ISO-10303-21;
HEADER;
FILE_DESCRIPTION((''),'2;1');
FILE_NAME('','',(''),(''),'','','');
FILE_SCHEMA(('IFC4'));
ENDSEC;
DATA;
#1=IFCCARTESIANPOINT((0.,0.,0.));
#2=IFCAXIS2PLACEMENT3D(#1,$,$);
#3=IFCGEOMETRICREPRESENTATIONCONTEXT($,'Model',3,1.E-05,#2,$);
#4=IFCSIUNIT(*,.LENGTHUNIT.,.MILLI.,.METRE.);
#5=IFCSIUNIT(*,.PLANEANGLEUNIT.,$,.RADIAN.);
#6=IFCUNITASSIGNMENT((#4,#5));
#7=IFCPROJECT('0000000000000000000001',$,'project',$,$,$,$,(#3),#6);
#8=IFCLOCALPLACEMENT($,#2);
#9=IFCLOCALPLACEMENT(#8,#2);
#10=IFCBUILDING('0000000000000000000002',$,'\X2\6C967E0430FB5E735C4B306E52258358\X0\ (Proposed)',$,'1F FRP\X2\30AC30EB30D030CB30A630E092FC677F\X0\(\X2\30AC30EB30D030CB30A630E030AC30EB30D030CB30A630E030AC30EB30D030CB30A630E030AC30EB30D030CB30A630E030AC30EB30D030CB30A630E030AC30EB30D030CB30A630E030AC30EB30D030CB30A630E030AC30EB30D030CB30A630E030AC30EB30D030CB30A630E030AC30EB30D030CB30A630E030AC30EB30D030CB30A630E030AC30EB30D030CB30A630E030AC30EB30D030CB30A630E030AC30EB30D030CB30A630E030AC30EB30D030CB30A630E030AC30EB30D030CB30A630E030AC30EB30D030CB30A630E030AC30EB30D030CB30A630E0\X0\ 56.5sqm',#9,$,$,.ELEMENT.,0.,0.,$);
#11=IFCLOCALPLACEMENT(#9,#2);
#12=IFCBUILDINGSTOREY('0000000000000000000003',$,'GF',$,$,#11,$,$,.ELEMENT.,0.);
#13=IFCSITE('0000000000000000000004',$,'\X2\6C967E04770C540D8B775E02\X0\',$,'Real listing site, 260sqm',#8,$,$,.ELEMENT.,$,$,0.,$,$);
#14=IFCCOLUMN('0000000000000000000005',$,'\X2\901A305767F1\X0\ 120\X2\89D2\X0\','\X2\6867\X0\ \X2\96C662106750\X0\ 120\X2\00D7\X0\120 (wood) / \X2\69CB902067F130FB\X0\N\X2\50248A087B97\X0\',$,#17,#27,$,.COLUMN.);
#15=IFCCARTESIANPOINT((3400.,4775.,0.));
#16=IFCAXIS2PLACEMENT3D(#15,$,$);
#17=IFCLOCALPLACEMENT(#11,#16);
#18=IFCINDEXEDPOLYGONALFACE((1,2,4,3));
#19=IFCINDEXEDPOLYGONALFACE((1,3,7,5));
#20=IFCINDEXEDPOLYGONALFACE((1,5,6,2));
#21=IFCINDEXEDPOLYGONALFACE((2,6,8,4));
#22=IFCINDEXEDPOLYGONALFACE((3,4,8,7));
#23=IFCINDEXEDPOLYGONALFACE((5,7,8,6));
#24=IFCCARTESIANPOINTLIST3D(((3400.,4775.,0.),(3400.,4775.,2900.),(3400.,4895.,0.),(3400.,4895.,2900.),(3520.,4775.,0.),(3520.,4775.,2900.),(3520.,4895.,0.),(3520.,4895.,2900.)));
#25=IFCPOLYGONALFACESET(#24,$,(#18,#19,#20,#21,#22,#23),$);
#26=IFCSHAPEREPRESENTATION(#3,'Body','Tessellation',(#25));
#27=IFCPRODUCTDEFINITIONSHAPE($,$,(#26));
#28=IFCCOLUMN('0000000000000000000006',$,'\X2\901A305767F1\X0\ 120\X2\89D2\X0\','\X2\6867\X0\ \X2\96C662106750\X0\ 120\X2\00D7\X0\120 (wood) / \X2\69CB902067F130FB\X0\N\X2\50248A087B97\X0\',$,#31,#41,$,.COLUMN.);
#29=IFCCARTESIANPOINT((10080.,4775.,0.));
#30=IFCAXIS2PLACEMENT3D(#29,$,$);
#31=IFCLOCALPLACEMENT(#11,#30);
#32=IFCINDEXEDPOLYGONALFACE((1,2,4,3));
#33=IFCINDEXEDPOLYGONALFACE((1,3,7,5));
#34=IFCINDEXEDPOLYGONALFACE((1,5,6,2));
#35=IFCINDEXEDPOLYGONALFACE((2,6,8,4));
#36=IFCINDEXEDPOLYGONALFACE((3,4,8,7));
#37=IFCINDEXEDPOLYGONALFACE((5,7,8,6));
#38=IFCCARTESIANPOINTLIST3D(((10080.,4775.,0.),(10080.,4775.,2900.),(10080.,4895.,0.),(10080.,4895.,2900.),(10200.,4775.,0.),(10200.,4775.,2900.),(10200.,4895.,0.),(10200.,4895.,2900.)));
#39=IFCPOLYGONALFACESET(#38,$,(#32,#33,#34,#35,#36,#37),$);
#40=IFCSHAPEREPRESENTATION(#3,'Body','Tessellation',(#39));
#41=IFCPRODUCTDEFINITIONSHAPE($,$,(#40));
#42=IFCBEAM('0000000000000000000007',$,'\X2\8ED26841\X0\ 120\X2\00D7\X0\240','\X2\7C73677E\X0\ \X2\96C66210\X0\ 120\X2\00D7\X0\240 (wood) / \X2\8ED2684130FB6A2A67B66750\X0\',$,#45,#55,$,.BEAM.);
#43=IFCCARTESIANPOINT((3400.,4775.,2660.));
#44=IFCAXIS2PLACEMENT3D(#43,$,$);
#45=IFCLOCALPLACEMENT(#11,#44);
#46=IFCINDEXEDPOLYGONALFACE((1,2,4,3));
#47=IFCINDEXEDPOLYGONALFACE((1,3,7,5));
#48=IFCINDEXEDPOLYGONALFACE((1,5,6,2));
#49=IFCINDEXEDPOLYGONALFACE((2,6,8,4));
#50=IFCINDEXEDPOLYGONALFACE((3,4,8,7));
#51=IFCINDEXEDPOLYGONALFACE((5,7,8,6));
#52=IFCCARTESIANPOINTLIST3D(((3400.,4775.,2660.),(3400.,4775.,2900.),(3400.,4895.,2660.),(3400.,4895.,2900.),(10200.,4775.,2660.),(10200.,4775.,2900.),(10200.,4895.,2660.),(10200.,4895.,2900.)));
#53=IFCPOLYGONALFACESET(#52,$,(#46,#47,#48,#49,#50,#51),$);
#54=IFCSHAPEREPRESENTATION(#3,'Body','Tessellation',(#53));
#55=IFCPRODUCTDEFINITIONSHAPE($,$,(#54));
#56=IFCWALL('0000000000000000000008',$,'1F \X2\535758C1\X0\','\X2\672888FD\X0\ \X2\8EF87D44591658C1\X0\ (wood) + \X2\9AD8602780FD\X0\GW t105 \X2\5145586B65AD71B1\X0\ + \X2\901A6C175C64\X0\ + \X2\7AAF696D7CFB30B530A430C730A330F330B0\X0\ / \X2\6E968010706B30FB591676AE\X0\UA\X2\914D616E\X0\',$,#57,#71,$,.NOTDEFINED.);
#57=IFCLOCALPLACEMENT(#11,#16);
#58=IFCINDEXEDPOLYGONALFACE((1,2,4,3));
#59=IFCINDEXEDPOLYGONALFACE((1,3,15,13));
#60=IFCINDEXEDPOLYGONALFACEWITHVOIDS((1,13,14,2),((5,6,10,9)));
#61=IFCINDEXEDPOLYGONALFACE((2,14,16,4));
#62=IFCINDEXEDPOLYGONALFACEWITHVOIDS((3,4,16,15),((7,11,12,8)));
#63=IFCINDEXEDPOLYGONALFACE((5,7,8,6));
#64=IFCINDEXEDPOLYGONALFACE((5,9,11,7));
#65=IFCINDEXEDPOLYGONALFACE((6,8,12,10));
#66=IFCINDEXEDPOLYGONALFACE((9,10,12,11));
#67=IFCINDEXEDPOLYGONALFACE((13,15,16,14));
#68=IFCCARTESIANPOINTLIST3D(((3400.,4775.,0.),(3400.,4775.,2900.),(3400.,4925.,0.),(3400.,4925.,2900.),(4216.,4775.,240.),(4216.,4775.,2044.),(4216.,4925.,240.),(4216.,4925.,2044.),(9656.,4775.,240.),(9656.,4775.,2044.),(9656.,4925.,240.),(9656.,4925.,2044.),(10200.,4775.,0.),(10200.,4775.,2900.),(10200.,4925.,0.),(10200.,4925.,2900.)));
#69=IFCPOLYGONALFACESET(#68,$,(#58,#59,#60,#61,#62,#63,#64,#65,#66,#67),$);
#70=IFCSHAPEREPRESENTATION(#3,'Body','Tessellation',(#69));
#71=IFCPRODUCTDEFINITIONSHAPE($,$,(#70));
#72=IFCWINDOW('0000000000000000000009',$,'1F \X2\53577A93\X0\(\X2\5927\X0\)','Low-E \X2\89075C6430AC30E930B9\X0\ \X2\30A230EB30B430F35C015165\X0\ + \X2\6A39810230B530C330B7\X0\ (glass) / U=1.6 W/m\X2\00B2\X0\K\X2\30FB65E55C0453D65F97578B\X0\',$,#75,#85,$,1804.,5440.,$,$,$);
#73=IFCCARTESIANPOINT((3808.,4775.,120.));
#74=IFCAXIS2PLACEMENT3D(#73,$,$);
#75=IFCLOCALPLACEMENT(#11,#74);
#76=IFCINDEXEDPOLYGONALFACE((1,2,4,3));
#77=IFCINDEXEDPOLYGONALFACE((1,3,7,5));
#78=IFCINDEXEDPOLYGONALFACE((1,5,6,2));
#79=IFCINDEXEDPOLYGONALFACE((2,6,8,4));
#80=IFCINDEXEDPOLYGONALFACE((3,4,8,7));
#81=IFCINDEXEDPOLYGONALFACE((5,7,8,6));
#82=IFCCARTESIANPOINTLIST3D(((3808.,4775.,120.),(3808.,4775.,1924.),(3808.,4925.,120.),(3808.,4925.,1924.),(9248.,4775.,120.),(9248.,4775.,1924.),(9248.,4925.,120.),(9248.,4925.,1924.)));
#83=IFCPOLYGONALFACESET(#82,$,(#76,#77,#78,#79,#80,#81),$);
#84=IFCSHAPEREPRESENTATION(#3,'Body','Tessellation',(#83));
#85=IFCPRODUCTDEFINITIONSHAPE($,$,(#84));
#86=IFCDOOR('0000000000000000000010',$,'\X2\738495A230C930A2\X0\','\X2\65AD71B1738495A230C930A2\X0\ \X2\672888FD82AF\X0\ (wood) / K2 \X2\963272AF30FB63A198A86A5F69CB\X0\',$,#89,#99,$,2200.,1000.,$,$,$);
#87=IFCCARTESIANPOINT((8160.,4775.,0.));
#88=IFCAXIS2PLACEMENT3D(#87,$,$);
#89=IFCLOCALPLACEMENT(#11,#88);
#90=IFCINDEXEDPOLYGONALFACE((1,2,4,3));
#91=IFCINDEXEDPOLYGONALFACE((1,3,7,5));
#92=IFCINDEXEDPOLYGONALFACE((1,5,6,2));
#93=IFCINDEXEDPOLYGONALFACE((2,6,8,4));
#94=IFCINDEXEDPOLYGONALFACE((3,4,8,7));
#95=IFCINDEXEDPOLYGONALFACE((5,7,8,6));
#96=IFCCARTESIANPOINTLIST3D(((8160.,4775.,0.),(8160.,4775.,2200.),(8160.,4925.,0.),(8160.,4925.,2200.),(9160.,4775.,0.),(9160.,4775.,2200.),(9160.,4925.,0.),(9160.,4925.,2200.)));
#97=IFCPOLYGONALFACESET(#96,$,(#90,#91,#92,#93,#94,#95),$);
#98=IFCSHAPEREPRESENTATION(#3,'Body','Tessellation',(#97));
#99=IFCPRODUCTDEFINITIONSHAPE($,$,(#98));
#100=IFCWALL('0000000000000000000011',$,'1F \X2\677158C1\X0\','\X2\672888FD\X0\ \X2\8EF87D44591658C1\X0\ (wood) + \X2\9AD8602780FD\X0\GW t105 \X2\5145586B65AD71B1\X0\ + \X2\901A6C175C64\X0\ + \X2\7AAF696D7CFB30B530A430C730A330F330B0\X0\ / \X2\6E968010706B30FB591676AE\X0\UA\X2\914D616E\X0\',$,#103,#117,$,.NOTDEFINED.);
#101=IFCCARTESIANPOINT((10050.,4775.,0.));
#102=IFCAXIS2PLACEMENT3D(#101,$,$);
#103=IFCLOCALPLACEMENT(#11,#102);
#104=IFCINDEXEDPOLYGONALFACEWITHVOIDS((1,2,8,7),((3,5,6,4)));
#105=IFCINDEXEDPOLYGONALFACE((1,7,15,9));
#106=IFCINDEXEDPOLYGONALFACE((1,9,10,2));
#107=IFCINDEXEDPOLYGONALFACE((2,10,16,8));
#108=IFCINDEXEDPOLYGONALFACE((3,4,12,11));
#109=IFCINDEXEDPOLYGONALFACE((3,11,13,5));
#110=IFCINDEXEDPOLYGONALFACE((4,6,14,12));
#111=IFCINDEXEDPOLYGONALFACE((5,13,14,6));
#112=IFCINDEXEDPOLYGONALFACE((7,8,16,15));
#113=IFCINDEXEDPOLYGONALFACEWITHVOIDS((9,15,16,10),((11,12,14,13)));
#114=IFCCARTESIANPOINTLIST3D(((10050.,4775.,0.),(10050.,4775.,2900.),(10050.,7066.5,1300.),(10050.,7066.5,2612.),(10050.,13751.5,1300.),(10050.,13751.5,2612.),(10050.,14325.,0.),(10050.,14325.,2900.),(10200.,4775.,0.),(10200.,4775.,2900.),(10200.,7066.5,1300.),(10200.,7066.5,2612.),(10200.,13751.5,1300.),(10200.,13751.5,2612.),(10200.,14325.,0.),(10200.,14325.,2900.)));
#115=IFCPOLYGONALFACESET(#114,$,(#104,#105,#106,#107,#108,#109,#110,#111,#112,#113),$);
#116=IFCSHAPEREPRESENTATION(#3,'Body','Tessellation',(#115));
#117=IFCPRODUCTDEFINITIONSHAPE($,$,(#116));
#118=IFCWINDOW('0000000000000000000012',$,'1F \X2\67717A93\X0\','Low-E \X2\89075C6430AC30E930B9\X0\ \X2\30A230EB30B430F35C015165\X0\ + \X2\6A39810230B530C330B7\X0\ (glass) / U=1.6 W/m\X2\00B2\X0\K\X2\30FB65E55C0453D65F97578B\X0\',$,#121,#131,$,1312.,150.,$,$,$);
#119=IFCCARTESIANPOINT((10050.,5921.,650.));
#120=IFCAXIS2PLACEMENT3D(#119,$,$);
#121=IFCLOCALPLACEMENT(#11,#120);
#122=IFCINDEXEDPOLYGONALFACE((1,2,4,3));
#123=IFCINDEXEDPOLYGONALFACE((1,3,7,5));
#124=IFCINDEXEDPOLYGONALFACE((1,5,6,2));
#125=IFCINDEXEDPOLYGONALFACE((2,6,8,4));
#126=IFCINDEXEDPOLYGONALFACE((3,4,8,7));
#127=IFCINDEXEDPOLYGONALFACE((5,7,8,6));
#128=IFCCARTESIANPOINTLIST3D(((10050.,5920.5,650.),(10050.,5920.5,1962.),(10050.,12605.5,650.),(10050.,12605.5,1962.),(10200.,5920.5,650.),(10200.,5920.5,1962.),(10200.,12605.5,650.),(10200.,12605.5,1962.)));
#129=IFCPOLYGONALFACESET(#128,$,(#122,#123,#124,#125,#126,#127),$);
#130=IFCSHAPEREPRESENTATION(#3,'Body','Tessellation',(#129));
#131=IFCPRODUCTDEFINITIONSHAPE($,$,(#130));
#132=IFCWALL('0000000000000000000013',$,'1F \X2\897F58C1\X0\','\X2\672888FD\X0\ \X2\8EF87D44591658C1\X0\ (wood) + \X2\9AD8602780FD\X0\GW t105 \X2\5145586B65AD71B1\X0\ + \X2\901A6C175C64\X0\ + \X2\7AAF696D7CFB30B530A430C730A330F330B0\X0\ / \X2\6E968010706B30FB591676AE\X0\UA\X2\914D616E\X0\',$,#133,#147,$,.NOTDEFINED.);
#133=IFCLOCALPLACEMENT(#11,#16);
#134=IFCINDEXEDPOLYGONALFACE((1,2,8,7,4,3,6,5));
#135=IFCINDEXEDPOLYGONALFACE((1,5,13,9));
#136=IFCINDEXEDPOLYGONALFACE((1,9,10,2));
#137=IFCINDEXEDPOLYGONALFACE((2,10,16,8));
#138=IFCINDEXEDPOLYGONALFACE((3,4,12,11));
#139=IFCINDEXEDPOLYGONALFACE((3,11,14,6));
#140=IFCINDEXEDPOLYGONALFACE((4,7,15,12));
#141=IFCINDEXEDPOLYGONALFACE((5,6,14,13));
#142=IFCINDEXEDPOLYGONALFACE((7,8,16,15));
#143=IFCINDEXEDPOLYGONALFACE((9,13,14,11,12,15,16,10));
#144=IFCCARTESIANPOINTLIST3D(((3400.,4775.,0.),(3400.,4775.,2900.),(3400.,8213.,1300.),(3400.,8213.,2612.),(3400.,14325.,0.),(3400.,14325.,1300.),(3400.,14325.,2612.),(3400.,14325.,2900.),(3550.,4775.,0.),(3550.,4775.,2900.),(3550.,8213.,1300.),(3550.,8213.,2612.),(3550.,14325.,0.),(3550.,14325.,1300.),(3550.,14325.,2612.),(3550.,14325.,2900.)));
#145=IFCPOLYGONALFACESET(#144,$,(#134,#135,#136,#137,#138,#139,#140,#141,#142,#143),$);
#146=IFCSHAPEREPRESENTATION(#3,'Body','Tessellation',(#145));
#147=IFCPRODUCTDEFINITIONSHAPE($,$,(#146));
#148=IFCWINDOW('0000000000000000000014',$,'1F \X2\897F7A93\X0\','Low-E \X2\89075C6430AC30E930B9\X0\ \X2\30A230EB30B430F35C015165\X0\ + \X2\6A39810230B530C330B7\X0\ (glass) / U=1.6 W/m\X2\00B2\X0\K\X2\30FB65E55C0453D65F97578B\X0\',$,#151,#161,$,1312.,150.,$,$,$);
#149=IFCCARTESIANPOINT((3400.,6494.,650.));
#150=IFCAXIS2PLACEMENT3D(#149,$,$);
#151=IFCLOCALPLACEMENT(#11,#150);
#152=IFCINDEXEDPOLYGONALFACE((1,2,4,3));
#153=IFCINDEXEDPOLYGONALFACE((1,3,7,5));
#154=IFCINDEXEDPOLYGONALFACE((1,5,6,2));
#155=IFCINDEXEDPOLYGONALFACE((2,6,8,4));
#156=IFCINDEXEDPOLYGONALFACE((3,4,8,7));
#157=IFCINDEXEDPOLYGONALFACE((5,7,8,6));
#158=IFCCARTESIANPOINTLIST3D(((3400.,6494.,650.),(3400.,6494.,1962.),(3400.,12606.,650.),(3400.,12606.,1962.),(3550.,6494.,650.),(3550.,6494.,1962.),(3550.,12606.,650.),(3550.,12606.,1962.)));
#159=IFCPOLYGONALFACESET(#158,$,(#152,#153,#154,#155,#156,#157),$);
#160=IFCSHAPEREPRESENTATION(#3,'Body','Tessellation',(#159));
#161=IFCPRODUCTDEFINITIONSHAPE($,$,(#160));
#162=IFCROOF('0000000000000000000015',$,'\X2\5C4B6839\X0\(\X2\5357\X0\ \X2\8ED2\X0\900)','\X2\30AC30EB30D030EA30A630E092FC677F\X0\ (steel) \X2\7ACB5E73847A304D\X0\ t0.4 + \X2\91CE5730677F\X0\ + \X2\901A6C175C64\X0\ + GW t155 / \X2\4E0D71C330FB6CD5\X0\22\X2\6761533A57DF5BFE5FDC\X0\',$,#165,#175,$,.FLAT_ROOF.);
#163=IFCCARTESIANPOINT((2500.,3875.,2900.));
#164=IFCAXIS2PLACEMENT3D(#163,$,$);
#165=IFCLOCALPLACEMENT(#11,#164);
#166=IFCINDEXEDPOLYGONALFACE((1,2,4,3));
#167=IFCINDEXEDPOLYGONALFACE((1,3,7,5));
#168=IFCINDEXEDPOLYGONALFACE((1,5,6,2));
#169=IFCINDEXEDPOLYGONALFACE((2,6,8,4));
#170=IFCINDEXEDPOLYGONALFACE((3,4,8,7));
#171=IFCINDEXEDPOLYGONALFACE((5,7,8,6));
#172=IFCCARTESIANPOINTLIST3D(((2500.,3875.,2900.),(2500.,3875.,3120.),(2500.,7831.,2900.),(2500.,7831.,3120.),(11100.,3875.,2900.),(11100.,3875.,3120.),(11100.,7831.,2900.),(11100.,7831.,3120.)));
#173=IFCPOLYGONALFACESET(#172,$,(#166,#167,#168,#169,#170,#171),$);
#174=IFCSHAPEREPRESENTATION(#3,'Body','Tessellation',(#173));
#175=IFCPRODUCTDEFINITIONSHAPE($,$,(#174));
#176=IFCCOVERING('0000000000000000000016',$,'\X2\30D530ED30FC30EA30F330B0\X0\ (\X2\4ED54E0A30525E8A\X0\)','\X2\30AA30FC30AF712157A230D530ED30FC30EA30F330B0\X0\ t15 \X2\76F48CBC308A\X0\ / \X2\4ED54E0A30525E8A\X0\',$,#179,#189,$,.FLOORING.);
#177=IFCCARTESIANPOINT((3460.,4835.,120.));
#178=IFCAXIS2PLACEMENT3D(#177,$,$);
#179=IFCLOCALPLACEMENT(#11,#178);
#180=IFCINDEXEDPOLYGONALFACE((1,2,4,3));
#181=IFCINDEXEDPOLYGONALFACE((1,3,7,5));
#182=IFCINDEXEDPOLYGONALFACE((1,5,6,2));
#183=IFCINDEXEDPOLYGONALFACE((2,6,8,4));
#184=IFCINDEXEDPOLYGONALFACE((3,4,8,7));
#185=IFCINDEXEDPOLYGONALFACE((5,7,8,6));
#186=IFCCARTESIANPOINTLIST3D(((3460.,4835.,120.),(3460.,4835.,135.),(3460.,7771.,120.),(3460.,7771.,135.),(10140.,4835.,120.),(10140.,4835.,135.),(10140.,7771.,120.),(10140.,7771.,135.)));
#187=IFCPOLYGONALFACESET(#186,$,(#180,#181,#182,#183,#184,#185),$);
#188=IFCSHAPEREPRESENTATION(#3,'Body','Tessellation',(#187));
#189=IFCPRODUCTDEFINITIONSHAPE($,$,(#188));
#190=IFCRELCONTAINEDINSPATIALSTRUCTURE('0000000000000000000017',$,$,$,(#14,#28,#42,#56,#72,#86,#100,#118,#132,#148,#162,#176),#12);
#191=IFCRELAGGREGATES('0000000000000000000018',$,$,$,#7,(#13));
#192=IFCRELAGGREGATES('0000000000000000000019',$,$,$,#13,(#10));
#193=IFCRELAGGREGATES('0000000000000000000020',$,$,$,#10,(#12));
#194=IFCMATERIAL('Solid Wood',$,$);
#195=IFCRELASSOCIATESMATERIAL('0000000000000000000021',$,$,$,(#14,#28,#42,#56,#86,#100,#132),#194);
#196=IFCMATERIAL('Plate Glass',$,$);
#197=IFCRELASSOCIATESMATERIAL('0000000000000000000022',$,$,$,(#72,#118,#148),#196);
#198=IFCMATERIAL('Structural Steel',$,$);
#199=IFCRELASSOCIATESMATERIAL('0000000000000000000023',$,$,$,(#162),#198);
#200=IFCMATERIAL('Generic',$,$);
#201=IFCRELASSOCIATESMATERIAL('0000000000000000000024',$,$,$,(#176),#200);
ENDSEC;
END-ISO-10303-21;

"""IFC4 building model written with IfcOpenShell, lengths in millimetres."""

from ifc_helpers import new_model, si_unit, frame, frame_2d, origin, place, context, project, spatial, rectangle, extrude, material, element, fill, save


model = new_model("IFC4")

# Units and contexts
model_context = context("Model", 3, precision=1e-05, world=origin())
ifc_project = project(units=[si_unit("LENGTHUNIT", "METRE", prefix="MILLI"), si_unit("PLANEANGLEUNIT", "RADIAN")], contexts=[model_context])

# Site, building, storey
site_placement = place(None, origin())
site = spatial("IfcSite", under=ifc_project, at=site_placement, Name="沖縄県名護市", ObjectType="Real listing site, 260sqm", CompositionType="ELEMENT", RefElevation=0.0)
building_placement = place(site_placement, origin())
building = spatial("IfcBuilding", under=site, at=building_placement, Name="沖縄・平屋の別荘 (Proposed)", ObjectType="1F FRPガルバニウム鋼板(ガルバニウムガルバニウムガルバニウムガルバニウムガルバニウムガルバニウムガルバニウムガルバニウムガルバニウムガルバニウムガルバニウムガルバニウムガルバニウムガルバニウムガルバニウムガルバニウムガルバニウムガルバニウム 56.5sqm", CompositionType="ELEMENT", ElevationOfRefHeight=0.0, ElevationOfTerrain=0.0)
storey_placement = place(building_placement, origin())
storey = spatial("IfcBuildingStorey", under=building, at=storey_placement, Name="GF", CompositionType="ELEMENT", Elevation=0.0)

# Columns
ifc_material_1 = material(Name="Solid Wood")
column_1_placement = place(storey_placement, frame((3400.0, 4775.0, 0.0)))
element("IfcColumn", 1, at=column_1_placement, inside=storey, material=ifc_material_1, Name="通し柱 120角", Description="桧 集成材 120×120 (wood) / 構造柱・N値計算", PredefinedType="COLUMN", context=model_context, shape_type="SweptSolid", body=[
    extrude(rectangle(XDim=120.0, YDim=120.0, at=frame_2d((60.0, 60.0))), frame((3400.0, 4775.0, 0.0)), (0.0, 0.0, 1.0), 2900.0),
])
column_2_placement = place(storey_placement, frame((10080.0, 4775.0, 0.0)))
element("IfcColumn", 2, at=column_2_placement, inside=storey, material=ifc_material_1, Name="通し柱 120角", Description="桧 集成材 120×120 (wood) / 構造柱・N値計算", PredefinedType="COLUMN", context=model_context, shape_type="SweptSolid", body=[
    extrude(rectangle(XDim=120.0, YDim=120.0, at=frame_2d((60.0, 60.0))), frame((10080.0, 4775.0, 0.0)), (0.0, 0.0, 1.0), 2900.0),
])

# Beam
beam_1_placement = place(storey_placement, frame((3400.0, 4775.0, 2660.0)))
element("IfcBeam", 3, at=beam_1_placement, inside=storey, material=ifc_material_1, Name="軒桁 120×240", Description="米松 集成 120×240 (wood) / 軒桁・横架材", PredefinedType="BEAM", context=model_context, shape_type="SweptSolid", body=[
    extrude(rectangle(XDim=6800.0, YDim=120.0, at=frame_2d((3400.0, 60.0))), frame((3400.0, 4775.0, 2660.0)), (0.0, 0.0, 1.0), 240.0),
])

# Wall, openings, window, door
wall_1_placement = place(storey_placement, frame((3400.0, 4775.0, 0.0)))
wall_1 = element("IfcWall", 4, at=wall_1_placement, inside=storey, material=ifc_material_1, Name="1F 南壁", Description="木製 軸組外壁 (wood) + 高性能GW t105 充填断熱 + 通気層 + 窯業系サイディング / 準耐火・外皮UA配慮", PredefinedType="NOTDEFINED", context=model_context, shape_type="SweptSolid", body=[
    extrude(rectangle(XDim=6800.0, YDim=150.0, at=frame_2d((3400.0, 75.0))), frame((3400.0, 4775.0, 0.0)), (0.0, 0.0, 1.0), 2900.0),
])
opening_1_placement = place(storey_placement, frame((3808.0, 4775.0, 120.0)))
opening_1 = element("IfcOpeningElement", 5, at=opening_1_placement, cuts=wall_1, PredefinedType="NOTDEFINED", context=model_context, shape_type="SweptSolid", body=[
    extrude(rectangle(XDim=5440.0, YDim=150.0, at=frame_2d((2720.0, 75.0))), frame((3808.0, 4775.0, 120.0)), (0.0, 0.0, 1.0), 1804.0),
])
opening_2_placement = place(storey_placement, frame((8160.0, 4775.0, 0.0)))
opening_2 = element("IfcOpeningElement", 6, at=opening_2_placement, cuts=wall_1, PredefinedType="NOTDEFINED", context=model_context, shape_type="SweptSolid", body=[
    extrude(rectangle(XDim=1000.0, YDim=150.0, at=frame_2d((500.0, 75.0))), frame((8160.0, 4775.0, 0.0)), (0.0, 0.0, 1.0), 2200.0),
])
ifc_material_2 = material(Name="Plate Glass")
window_1_placement = place(storey_placement, frame((3808.0, 4775.0, 120.0)))
window_1 = element("IfcWindow", 7, at=window_1_placement, inside=storey, material=ifc_material_2, Name="1F 南窓(大)", Description="Low-E 複層ガラス アルゴン封入 + 樹脂サッシ (glass) / U=1.6 W/m²K・日射取得型", OverallHeight=1804.0, OverallWidth=5440.0, context=model_context, shape_type="SweptSolid", body=[
    extrude(rectangle(XDim=5440.0, YDim=150.0, at=frame_2d((2720.0, 75.0))), frame((3808.0, 4775.0, 120.0)), (0.0, 0.0, 1.0), 1804.0),
])
fill(opening_1, window_1)
door_placement = place(storey_placement, frame((8160.0, 4775.0, 0.0)))
door = element("IfcDoor", 8, at=door_placement, inside=storey, material=ifc_material_1, Name="玄関ドア", Description="断熱玄関ドア 木製芯 (wood) / K2 防犯・採風機構", OverallHeight=2200.0, OverallWidth=1000.0, context=model_context, shape_type="SweptSolid", body=[
    extrude(rectangle(XDim=1000.0, YDim=150.0, at=frame_2d((500.0, 75.0))), frame((8160.0, 4775.0, 0.0)), (0.0, 0.0, 1.0), 2200.0),
])
fill(opening_2, door)

# Walls, openings, windows
wall_2_placement = place(storey_placement, frame((10050.0, 4775.0, 0.0)))
wall_2 = element("IfcWall", 9, at=wall_2_placement, inside=storey, material=ifc_material_1, Name="1F 東壁", Description="木製 軸組外壁 (wood) + 高性能GW t105 充填断熱 + 通気層 + 窯業系サイディング / 準耐火・外皮UA配慮", PredefinedType="NOTDEFINED", context=model_context, shape_type="SweptSolid", body=[
    extrude(rectangle(XDim=150.0, YDim=9550.0, at=frame_2d((75.0, 4775.0))), frame((10050.0, 4775.0, 0.0)), (0.0, 0.0, 1.0), 2900.0),
])
opening_3_placement = place(storey_placement, frame((10050.0, 5921.0, 650.0)))
opening_3 = element("IfcOpeningElement", 10, at=opening_3_placement, cuts=wall_2, PredefinedType="NOTDEFINED", context=model_context, shape_type="SweptSolid", body=[
    extrude(rectangle(XDim=150.0, YDim=6685.0, at=frame_2d((75.0, 3342.0))), frame((10050.0, 5921.0, 650.0)), (0.0, 0.0, 1.0), 1312.0),
])
window_2_placement = place(storey_placement, frame((10050.0, 5921.0, 650.0)))
window_2 = element("IfcWindow", 11, at=window_2_placement, inside=storey, material=ifc_material_2, Name="1F 東窓", Description="Low-E 複層ガラス アルゴン封入 + 樹脂サッシ (glass) / U=1.6 W/m²K・日射取得型", OverallHeight=1312.0, OverallWidth=150.0, context=model_context, shape_type="SweptSolid", body=[
    extrude(rectangle(XDim=150.0, YDim=6685.0, at=frame_2d((75.0, 3342.0))), frame((10050.0, 5921.0, 650.0)), (0.0, 0.0, 1.0), 1312.0),
])
fill(opening_3, window_2)
wall_3_placement = place(storey_placement, frame((3400.0, 4775.0, 0.0)))
wall_3 = element("IfcWall", 12, at=wall_3_placement, inside=storey, material=ifc_material_1, Name="1F 西壁", Description="木製 軸組外壁 (wood) + 高性能GW t105 充填断熱 + 通気層 + 窯業系サイディング / 準耐火・外皮UA配慮", PredefinedType="NOTDEFINED", context=model_context, shape_type="SweptSolid", body=[
    extrude(rectangle(XDim=150.0, YDim=9550.0, at=frame_2d((75.0, 4775.0))), frame((3400.0, 4775.0, 0.0)), (0.0, 0.0, 1.0), 2900.0),
])
opening_4_placement = place(storey_placement, frame((3400.0, 6494.0, 650.0)))
opening_4 = element("IfcOpeningElement", 13, at=opening_4_placement, cuts=wall_3, PredefinedType="NOTDEFINED", context=model_context, shape_type="SweptSolid", body=[
    extrude(rectangle(XDim=150.0, YDim=6112.0, at=frame_2d((75.0, 3056.0))), frame((3400.0, 6494.0, 650.0)), (0.0, 0.0, 1.0), 1312.0),
])
window_3_placement = place(storey_placement, frame((3400.0, 6494.0, 650.0)))
window_3 = element("IfcWindow", 14, at=window_3_placement, inside=storey, material=ifc_material_2, Name="1F 西窓", Description="Low-E 複層ガラス アルゴン封入 + 樹脂サッシ (glass) / U=1.6 W/m²K・日射取得型", OverallHeight=1312.0, OverallWidth=150.0, context=model_context, shape_type="SweptSolid", body=[
    extrude(rectangle(XDim=150.0, YDim=6112.0, at=frame_2d((75.0, 3056.0))), frame((3400.0, 6494.0, 650.0)), (0.0, 0.0, 1.0), 1312.0),
])
fill(opening_4, window_3)

# Roof
ifc_material_3 = material(Name="Structural Steel")
roof_placement = place(storey_placement, frame((2500.0, 3875.0, 2900.0)))
element("IfcRoof", 15, at=roof_placement, inside=storey, material=ifc_material_3, Name="屋根(南 軒900)", Description="ガルバリウム鋼板 (steel) 立平葺き t0.4 + 野地板 + 通気層 + GW t155 / 不燃・法22条区域対応", PredefinedType="FLAT_ROOF", context=model_context, shape_type="SweptSolid", body=[
    extrude(rectangle(XDim=8600.0, YDim=3956.0, at=frame_2d((4300.0, 1978.0))), frame((2500.0, 3875.0, 2900.0)), (0.0, 0.0, 1.0), 220.0),
])

# Covering
ifc_material_4 = material(Name="Generic")
covering_1_placement = place(storey_placement, frame((3460.0, 4835.0, 120.0)))
element("IfcCovering", 16, at=covering_1_placement, inside=storey, material=ifc_material_4, Name="フローリング (仕上げ床)", Description="オーク無垢フローリング t15 直貼り / 仕上げ床", PredefinedType="FLOORING", context=model_context, shape_type="SweptSolid", body=[
    extrude(rectangle(XDim=6680.0, YDim=2936.0, at=frame_2d((3340.0, 1468.0))), frame((3460.0, 4835.0, 120.0)), (0.0, 0.0, 1.0), 15.0),
])

save(model, "model.ifc")
